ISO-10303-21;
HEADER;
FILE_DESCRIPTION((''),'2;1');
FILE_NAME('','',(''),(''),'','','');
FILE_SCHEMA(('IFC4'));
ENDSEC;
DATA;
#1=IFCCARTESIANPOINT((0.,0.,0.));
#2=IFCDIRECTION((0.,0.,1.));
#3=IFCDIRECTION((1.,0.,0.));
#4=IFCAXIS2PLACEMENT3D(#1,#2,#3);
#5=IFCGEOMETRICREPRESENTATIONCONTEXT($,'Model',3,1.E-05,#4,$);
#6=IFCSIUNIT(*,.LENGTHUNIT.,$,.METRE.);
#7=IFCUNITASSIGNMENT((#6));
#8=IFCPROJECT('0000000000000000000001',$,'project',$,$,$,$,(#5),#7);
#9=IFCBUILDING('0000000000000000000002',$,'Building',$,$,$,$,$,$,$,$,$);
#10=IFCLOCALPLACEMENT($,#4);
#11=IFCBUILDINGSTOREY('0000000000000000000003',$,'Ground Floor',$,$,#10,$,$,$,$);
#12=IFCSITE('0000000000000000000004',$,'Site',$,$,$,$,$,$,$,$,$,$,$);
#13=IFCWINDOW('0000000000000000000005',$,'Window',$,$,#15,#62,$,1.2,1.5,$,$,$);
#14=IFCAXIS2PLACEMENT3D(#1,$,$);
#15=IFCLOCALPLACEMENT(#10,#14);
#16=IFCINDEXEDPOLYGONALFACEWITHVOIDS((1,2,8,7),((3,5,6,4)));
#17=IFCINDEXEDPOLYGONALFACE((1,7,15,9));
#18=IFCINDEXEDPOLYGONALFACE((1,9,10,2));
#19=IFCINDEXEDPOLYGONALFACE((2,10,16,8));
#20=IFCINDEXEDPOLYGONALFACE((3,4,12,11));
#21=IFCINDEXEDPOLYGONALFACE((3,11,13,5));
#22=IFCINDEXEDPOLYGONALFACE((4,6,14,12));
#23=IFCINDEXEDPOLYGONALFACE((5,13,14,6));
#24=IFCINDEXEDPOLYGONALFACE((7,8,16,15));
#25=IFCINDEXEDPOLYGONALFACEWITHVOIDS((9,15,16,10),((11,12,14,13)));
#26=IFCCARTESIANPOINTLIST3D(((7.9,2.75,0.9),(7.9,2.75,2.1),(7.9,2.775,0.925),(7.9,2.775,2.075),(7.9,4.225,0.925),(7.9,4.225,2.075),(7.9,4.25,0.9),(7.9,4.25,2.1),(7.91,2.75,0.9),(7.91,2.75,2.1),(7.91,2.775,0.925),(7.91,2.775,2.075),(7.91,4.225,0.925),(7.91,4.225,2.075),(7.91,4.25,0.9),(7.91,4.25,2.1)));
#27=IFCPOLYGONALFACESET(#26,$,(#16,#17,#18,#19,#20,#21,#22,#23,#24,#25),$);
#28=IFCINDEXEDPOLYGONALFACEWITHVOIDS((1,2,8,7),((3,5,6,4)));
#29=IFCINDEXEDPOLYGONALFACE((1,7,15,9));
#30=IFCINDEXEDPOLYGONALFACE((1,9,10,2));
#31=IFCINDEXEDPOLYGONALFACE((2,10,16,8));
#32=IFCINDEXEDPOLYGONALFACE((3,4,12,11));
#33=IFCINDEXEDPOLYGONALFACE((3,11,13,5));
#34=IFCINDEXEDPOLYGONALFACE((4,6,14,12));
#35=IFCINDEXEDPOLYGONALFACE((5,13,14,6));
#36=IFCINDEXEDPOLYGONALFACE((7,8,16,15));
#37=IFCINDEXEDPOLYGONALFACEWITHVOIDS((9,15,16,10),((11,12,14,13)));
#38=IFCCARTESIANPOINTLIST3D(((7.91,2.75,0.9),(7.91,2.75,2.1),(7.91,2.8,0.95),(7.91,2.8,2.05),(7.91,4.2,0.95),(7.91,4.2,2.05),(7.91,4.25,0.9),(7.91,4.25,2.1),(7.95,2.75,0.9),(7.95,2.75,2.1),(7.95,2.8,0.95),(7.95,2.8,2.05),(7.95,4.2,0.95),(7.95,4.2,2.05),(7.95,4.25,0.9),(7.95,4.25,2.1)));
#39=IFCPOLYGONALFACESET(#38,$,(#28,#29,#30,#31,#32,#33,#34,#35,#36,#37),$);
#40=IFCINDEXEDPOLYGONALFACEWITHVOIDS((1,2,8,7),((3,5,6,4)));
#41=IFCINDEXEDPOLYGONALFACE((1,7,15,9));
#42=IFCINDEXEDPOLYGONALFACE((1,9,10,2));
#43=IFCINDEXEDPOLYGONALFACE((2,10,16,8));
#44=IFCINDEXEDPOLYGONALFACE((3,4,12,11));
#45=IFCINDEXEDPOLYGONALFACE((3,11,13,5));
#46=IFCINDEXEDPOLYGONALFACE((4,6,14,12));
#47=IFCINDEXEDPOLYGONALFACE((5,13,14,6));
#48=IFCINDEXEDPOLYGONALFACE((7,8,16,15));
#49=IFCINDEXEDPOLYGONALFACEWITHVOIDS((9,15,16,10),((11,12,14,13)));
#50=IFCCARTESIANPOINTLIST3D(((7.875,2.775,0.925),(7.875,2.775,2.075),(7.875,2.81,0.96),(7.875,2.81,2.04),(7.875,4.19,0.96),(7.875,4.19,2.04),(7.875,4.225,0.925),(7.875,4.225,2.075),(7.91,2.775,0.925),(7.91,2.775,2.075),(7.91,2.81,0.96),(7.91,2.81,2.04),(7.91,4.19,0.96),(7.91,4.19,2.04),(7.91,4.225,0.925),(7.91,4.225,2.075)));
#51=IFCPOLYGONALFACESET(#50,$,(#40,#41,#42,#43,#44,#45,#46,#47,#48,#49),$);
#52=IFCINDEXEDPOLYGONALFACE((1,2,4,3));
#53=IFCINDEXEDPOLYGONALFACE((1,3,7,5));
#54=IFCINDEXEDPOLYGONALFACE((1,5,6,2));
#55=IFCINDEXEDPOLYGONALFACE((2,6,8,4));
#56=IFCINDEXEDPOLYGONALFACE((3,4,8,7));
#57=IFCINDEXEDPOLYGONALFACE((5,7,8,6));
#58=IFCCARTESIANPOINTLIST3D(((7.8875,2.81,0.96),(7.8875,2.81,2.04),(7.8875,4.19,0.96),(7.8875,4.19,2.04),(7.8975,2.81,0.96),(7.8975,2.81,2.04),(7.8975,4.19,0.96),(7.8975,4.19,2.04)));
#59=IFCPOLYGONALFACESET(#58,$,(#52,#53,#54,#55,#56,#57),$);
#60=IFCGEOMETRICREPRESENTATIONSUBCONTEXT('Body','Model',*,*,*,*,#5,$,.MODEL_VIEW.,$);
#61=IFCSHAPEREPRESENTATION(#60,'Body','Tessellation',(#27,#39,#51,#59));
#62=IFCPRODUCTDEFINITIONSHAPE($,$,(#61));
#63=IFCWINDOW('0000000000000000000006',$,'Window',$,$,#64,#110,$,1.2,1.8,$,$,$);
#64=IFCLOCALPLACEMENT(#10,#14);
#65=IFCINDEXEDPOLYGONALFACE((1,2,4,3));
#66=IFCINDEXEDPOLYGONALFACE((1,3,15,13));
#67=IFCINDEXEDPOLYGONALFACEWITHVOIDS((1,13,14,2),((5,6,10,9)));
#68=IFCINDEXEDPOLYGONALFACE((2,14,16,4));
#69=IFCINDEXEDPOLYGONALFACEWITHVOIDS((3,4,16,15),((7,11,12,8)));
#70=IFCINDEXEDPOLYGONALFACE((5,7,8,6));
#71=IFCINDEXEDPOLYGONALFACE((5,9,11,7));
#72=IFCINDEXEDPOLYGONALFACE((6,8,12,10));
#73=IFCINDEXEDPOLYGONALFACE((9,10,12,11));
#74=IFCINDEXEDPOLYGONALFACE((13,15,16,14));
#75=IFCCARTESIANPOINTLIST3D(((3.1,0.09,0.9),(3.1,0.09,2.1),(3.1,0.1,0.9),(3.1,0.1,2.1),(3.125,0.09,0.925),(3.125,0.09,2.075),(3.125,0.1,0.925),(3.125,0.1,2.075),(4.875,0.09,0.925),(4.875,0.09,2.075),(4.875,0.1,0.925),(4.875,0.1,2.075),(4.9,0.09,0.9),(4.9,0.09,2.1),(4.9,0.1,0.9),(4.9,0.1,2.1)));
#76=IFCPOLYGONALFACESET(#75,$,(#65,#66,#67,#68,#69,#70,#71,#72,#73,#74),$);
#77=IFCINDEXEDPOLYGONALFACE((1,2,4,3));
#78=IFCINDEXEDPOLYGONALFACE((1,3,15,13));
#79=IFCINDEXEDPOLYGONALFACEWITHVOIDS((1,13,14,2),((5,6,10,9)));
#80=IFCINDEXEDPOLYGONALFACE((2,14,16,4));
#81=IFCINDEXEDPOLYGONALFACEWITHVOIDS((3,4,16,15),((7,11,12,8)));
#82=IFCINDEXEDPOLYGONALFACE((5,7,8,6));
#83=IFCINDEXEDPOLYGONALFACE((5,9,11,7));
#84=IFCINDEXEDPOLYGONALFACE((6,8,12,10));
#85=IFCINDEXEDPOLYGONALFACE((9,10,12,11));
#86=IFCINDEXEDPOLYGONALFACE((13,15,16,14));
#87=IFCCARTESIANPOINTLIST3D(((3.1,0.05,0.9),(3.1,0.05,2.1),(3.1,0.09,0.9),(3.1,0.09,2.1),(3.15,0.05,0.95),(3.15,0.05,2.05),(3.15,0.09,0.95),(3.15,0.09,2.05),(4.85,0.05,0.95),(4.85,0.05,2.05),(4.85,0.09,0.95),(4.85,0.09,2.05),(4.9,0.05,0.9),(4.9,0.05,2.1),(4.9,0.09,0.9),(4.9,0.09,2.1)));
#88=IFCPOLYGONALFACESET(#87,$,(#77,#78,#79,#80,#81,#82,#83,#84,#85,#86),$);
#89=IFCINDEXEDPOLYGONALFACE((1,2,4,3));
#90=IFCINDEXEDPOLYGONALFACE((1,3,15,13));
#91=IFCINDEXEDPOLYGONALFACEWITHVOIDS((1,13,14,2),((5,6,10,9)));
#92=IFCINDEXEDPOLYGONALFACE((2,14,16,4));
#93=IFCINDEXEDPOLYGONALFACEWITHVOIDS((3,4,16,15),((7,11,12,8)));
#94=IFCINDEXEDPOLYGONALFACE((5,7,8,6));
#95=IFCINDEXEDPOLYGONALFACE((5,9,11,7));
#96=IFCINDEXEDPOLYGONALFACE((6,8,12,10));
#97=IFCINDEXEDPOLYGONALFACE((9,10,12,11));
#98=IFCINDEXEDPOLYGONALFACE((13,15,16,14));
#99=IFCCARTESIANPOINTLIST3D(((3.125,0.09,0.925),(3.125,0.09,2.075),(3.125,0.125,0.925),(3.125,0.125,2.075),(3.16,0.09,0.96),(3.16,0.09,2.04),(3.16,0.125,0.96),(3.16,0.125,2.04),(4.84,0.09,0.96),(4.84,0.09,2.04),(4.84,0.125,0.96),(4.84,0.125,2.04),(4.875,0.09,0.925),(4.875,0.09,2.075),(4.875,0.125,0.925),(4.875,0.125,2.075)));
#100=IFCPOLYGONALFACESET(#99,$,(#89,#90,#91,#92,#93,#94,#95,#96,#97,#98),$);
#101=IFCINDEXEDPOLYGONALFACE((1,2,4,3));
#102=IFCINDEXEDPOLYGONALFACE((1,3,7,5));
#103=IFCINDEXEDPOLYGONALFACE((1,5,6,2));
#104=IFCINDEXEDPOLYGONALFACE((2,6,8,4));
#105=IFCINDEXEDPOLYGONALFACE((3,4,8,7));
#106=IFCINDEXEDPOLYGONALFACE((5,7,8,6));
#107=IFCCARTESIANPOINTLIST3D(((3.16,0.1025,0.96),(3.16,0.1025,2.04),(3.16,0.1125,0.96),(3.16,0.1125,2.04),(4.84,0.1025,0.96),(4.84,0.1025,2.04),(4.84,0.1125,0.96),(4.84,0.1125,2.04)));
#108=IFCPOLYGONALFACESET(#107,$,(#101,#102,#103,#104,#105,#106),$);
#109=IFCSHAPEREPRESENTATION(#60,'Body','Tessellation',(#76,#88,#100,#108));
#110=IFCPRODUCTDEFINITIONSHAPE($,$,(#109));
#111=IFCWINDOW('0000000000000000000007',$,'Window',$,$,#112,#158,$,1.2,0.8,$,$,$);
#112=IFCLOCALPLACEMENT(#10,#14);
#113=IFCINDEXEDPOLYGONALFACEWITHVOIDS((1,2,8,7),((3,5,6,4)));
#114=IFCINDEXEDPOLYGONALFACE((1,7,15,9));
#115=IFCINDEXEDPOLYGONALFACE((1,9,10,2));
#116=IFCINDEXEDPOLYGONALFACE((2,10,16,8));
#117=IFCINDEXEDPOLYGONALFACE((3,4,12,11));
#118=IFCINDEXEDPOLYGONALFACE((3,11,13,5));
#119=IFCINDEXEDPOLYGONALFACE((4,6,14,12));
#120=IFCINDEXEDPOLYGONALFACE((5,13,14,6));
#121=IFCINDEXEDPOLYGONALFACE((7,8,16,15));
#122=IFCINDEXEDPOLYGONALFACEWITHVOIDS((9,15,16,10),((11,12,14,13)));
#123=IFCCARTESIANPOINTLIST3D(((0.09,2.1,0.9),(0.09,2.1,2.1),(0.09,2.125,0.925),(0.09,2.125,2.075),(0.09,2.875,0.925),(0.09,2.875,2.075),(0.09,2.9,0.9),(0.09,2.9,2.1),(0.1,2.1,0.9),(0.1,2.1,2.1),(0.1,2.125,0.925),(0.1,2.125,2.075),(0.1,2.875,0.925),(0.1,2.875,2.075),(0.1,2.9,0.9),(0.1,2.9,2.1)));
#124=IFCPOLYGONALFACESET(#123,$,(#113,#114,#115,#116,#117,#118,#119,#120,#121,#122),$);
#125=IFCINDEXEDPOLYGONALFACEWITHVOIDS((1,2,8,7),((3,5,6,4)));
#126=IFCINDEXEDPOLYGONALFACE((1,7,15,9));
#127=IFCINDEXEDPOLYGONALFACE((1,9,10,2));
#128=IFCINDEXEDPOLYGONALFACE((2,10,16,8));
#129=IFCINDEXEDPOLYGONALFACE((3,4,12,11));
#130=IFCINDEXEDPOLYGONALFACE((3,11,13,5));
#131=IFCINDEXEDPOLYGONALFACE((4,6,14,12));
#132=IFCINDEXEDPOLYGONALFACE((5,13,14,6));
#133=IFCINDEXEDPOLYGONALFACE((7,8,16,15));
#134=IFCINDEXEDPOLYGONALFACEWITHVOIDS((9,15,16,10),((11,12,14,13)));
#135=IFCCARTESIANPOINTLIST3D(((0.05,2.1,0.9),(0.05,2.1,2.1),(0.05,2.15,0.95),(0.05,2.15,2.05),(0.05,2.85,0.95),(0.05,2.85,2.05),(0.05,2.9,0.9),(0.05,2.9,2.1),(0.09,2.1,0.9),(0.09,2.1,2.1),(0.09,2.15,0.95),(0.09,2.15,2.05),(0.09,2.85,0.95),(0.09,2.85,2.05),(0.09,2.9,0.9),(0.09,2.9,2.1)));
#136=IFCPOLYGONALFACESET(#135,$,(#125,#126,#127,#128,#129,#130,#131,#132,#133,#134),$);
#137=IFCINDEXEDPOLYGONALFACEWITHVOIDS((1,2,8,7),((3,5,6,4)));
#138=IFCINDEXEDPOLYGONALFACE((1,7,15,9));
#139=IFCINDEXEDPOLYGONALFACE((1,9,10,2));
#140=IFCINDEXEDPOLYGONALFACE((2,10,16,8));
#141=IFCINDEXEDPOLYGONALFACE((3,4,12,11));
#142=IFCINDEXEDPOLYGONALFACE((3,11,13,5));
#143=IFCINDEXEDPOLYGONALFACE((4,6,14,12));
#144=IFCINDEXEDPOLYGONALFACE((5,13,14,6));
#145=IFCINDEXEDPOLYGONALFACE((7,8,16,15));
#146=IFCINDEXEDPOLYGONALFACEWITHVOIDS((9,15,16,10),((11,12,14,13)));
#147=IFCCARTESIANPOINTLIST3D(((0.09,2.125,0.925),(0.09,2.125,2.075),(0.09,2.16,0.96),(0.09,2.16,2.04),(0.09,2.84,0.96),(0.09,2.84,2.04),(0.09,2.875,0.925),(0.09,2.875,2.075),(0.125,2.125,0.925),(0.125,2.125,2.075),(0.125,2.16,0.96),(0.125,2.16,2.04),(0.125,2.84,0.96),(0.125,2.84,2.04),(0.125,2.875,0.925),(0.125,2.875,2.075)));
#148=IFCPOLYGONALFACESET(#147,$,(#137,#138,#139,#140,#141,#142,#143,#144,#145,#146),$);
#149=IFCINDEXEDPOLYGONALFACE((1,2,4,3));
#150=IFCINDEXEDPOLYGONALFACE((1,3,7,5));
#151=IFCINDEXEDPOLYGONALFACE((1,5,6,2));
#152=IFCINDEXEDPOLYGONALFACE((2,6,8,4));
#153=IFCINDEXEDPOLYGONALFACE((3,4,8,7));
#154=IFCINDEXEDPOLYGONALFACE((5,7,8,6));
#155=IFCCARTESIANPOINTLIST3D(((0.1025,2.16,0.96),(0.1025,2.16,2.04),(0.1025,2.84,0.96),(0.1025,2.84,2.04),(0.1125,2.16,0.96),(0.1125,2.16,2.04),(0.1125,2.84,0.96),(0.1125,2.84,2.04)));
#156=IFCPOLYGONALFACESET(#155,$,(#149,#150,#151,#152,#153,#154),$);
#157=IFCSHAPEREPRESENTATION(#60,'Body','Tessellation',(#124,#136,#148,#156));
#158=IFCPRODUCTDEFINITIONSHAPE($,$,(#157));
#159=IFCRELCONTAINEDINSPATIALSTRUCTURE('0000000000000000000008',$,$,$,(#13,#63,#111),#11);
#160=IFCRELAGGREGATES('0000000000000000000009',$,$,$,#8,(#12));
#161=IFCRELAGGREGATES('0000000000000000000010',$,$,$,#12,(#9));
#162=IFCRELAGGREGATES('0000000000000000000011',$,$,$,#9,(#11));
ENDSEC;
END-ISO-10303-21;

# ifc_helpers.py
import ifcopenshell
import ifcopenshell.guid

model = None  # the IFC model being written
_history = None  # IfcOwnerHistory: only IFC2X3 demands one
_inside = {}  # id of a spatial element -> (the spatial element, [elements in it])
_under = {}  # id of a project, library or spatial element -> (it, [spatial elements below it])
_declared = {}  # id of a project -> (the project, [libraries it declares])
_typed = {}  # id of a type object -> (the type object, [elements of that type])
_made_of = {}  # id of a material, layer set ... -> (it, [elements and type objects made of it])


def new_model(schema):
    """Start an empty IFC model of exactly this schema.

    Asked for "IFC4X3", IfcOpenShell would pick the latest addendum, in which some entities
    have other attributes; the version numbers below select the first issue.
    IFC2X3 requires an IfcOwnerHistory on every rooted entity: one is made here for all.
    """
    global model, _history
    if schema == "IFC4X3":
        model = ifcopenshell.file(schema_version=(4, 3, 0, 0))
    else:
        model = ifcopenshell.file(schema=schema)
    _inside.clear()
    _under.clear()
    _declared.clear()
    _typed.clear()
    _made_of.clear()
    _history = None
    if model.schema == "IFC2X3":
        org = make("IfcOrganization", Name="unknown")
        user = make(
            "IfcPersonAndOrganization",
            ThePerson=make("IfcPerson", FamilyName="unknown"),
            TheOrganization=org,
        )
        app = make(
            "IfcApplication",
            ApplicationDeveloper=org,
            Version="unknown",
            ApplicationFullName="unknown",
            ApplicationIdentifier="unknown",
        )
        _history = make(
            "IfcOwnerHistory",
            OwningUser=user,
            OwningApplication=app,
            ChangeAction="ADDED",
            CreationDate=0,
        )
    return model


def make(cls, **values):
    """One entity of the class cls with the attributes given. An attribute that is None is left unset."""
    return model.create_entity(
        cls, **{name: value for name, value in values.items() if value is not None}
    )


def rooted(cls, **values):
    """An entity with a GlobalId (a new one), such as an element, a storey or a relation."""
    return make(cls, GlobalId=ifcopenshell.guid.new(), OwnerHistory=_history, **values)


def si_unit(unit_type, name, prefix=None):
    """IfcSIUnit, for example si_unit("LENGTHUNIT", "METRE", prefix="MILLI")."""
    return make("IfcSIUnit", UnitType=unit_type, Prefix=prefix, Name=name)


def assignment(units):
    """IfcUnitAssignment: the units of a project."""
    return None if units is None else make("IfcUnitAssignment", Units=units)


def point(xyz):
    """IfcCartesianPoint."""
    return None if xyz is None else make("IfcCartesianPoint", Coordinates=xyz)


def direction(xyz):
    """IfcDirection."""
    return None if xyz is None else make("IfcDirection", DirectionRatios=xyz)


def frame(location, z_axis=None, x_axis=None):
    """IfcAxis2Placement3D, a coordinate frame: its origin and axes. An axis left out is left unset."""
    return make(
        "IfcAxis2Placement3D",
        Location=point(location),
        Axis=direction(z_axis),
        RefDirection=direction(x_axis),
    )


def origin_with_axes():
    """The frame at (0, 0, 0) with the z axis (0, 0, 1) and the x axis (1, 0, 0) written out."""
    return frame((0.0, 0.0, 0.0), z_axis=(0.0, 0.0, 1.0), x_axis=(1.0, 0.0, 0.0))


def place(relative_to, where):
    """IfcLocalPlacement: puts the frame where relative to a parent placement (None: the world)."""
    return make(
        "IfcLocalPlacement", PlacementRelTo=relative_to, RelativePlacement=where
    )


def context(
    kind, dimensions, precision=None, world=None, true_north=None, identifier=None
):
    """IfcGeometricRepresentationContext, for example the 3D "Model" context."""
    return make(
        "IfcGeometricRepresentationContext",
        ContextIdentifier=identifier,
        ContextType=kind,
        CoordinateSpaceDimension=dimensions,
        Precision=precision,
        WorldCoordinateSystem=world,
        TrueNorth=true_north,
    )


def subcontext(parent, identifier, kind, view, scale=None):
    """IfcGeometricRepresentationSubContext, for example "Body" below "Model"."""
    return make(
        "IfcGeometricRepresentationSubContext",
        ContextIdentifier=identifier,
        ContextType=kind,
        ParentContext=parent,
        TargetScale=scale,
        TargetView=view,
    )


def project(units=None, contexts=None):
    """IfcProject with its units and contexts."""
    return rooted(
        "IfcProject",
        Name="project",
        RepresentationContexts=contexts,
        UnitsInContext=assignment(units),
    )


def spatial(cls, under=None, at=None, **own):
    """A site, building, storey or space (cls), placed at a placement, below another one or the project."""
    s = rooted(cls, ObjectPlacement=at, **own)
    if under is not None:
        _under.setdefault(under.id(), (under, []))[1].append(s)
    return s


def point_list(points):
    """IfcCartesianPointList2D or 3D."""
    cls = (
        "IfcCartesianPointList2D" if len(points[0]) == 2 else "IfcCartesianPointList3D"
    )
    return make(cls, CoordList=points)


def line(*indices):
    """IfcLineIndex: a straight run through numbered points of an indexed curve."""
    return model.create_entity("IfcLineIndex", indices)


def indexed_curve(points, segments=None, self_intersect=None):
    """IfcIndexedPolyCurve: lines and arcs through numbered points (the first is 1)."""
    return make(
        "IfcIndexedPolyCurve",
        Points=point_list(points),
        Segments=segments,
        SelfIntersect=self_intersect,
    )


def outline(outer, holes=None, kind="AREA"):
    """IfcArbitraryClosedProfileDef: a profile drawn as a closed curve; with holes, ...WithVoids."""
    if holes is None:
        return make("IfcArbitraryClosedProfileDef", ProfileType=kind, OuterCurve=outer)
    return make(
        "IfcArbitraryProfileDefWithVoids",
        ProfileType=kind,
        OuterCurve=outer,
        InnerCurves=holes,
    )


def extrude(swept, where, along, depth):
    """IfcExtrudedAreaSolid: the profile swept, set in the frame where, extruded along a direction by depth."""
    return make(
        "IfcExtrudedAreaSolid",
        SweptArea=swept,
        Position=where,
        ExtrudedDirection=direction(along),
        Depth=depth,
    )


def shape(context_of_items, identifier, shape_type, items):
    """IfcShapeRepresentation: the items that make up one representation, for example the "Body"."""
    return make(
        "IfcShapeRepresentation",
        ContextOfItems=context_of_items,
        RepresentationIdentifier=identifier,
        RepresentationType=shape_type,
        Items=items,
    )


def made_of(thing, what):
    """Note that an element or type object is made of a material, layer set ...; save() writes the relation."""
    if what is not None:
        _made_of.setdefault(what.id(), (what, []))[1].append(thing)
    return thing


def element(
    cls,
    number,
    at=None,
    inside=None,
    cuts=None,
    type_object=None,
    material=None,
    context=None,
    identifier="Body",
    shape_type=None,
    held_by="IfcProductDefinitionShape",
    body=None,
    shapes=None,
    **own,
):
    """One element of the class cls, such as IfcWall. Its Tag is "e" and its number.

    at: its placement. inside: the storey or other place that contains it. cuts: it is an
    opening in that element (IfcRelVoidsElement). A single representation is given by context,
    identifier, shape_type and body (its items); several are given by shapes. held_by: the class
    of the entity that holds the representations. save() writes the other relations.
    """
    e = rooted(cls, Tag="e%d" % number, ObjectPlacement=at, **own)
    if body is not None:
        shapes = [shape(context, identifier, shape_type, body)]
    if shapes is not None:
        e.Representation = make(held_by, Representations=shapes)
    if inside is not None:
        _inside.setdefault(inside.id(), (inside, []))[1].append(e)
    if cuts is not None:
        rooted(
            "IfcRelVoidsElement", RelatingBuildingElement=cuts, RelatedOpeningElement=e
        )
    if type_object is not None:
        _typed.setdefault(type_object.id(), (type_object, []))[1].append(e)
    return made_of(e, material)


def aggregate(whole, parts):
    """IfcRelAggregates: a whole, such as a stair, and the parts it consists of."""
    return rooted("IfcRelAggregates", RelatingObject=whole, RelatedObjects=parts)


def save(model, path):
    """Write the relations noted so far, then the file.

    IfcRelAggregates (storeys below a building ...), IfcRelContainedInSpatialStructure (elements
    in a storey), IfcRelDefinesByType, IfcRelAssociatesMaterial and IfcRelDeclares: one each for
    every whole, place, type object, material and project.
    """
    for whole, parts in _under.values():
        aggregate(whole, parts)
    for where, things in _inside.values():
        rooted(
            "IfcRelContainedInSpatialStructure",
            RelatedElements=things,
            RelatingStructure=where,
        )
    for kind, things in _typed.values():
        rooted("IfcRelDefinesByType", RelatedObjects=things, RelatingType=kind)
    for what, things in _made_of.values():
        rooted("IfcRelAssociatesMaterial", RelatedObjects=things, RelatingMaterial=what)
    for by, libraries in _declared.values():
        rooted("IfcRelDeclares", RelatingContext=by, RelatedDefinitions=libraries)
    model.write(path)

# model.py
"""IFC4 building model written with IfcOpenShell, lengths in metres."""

from ifc_helpers import new_model, si_unit, frame, origin_with_axes, place, context, subcontext, project, spatial, line, indexed_curve, outline, extrude, element, save


model = new_model("IFC4")

# Units and contexts
model_context = context("Model", 3, precision=1e-05, world=origin_with_axes())
body_context = subcontext(model_context, "Body", "Model", "MODEL_VIEW")
ifc_project = project(units=[si_unit("LENGTHUNIT", "METRE")], contexts=[model_context])

# Site, building, storey
site = spatial("IfcSite", under=ifc_project, Name="Site")
building = spatial("IfcBuilding", under=site, Name="Building")
storey_placement = place(None, origin_with_axes())
storey = spatial("IfcBuildingStorey", under=building, at=storey_placement, Name="Ground Floor")

# Windows
window_1_placement = place(storey_placement, frame((8.0, 2.75, 0.9), z_axis=(0.0, 0.0, 1.0), x_axis=(0.0, 1.0, 0.0)))
element("IfcWindow", 1, at=window_1_placement, inside=storey, Name="Window", OverallHeight=1.2, OverallWidth=1.5, context=body_context, shape_type="SweptSolid", body=[
    extrude(outline(indexed_curve([(0.0, 0.0), (1.5, 0.0), (1.5, 1.2), (0.0, 1.2)], segments=[line(1, 2, 3, 4, 1)]), holes=[indexed_curve([(0.025, 0.025), (1.475, 0.025), (1.475, 1.175), (0.025, 1.175)], segments=[line(1, 2, 3, 4, 1)])]), frame((0.0, 0.09, 0.0), z_axis=(0.0, -1.0, 0.0), x_axis=(1.0, 0.0, 0.0)), (0.0, 0.0, -1.0), 0.01),
    extrude(outline(indexed_curve([(0.0, 0.0), (1.5, 0.0), (1.5, 1.2), (0.0, 1.2)], segments=[line(1, 2, 3, 4, 1)]), holes=[indexed_curve([(0.05, 0.05), (1.45, 0.05), (1.45, 1.15), (0.05, 1.15)], segments=[line(1, 2, 3, 4, 1)])]), frame((0.0, 0.05, 0.0), z_axis=(0.0, -1.0, 0.0), x_axis=(1.0, 0.0, 0.0)), (0.0, 0.0, -1.0), 0.04),
    extrude(outline(indexed_curve([(0.0, 0.0), (1.45, 0.0), (1.45, 1.15), (0.0, 1.15)], segments=[line(1, 2, 3, 4, 1)]), holes=[indexed_curve([(0.035, 0.035), (1.415, 0.035), (1.415, 1.115), (0.035, 1.115)], segments=[line(1, 2, 3, 4, 1)])]), frame((0.025, 0.09, 0.025), z_axis=(0.0, -1.0, 0.0), x_axis=(1.0, 0.0, 0.0)), (0.0, 0.0, -1.0), 0.035),
    extrude(outline(indexed_curve([(0.035, 0.035), (1.415, 0.035), (1.415, 1.115), (0.035, 1.115)], segments=[line(1, 2, 3, 4, 1)])), frame((0.025, 0.1025, 0.025), z_axis=(0.0, -1.0, 0.0), x_axis=(1.0, 0.0, 0.0)), (0.0, 0.0, -1.0), 0.01),
])
window_2_placement = place(storey_placement, frame((3.1, 0.0, 0.9), z_axis=(0.0, 0.0, 1.0), x_axis=(1.0, 0.0, 0.0)))
element("IfcWindow", 2, at=window_2_placement, inside=storey, Name="Window", OverallHeight=1.2, OverallWidth=1.8, context=body_context, shape_type="SweptSolid", body=[
    extrude(outline(indexed_curve([(0.0, 0.0), (1.8, 0.0), (1.8, 1.2), (0.0, 1.2)], segments=[line(1, 2, 3, 4, 1)]), holes=[indexed_curve([(0.025, 0.025), (1.775, 0.025), (1.775, 1.175), (0.025, 1.175)], segments=[line(1, 2, 3, 4, 1)])]), frame((0.0, 0.09, 0.0), z_axis=(0.0, -1.0, 0.0), x_axis=(1.0, 0.0, 0.0)), (0.0, 0.0, -1.0), 0.01),
    extrude(outline(indexed_curve([(0.0, 0.0), (1.8, 0.0), (1.8, 1.2), (0.0, 1.2)], segments=[line(1, 2, 3, 4, 1)]), holes=[indexed_curve([(0.05, 0.05), (1.75, 0.05), (1.75, 1.15), (0.05, 1.15)], segments=[line(1, 2, 3, 4, 1)])]), frame((0.0, 0.05, 0.0), z_axis=(0.0, -1.0, 0.0), x_axis=(1.0, 0.0, 0.0)), (0.0, 0.0, -1.0), 0.04),
    extrude(outline(indexed_curve([(0.0, 0.0), (1.75, 0.0), (1.75, 1.15), (0.0, 1.15)], segments=[line(1, 2, 3, 4, 1)]), holes=[indexed_curve([(0.035, 0.035), (1.715, 0.035), (1.715, 1.115), (0.035, 1.115)], segments=[line(1, 2, 3, 4, 1)])]), frame((0.025, 0.09, 0.025), z_axis=(0.0, -1.0, 0.0), x_axis=(1.0, 0.0, 0.0)), (0.0, 0.0, -1.0), 0.035),
    extrude(outline(indexed_curve([(0.035, 0.035), (1.715, 0.035), (1.715, 1.115), (0.035, 1.115)], segments=[line(1, 2, 3, 4, 1)])), frame((0.025, 0.1025, 0.025), z_axis=(0.0, -1.0, 0.0), x_axis=(1.0, 0.0, 0.0)), (0.0, 0.0, -1.0), 0.01),
])
window_3_placement = place(storey_placement, frame((0.0, 2.9, 0.9), z_axis=(0.0, 0.0, 1.0), x_axis=(0.0, -1.0, 0.0)))
element("IfcWindow", 3, at=window_3_placement, inside=storey, Name="Window", OverallHeight=1.2, OverallWidth=0.8, context=body_context, shape_type="SweptSolid", body=[
    extrude(outline(indexed_curve([(0.0, 0.0), (0.8, 0.0), (0.8, 1.2), (0.0, 1.2)], segments=[line(1, 2, 3, 4, 1)]), holes=[indexed_curve([(0.025, 0.025), (0.775, 0.025), (0.775, 1.175), (0.025, 1.175)], segments=[line(1, 2, 3, 4, 1)])]), frame((0.0, 0.09, 0.0), z_axis=(0.0, -1.0, 0.0), x_axis=(1.0, 0.0, 0.0)), (0.0, 0.0, -1.0), 0.01),
    extrude(outline(indexed_curve([(0.0, 0.0), (0.8, 0.0), (0.8, 1.2), (0.0, 1.2)], segments=[line(1, 2, 3, 4, 1)]), holes=[indexed_curve([(0.05, 0.05), (0.75, 0.05), (0.75, 1.15), (0.05, 1.15)], segments=[line(1, 2, 3, 4, 1)])]), frame((0.0, 0.05, 0.0), z_axis=(0.0, -1.0, 0.0), x_axis=(1.0, 0.0, 0.0)), (0.0, 0.0, -1.0), 0.04),
    extrude(outline(indexed_curve([(0.0, 0.0), (0.75, 0.0), (0.75, 1.15), (0.0, 1.15)], segments=[line(1, 2, 3, 4, 1)]), holes=[indexed_curve([(0.035, 0.035), (0.715, 0.035), (0.715, 1.115), (0.035, 1.115)], segments=[line(1, 2, 3, 4, 1)])]), frame((0.025, 0.09, 0.025), z_axis=(0.0, -1.0, 0.0), x_axis=(1.0, 0.0, 0.0)), (0.0, 0.0, -1.0), 0.035),
    extrude(outline(indexed_curve([(0.035, 0.035), (0.715, 0.035), (0.715, 1.115), (0.035, 1.115)], segments=[line(1, 2, 3, 4, 1)])), frame((0.025, 0.1025, 0.025), z_axis=(0.0, -1.0, 0.0), x_axis=(1.0, 0.0, 0.0)), (0.0, 0.0, -1.0), 0.01),
])

save(model, "model.ifc")
